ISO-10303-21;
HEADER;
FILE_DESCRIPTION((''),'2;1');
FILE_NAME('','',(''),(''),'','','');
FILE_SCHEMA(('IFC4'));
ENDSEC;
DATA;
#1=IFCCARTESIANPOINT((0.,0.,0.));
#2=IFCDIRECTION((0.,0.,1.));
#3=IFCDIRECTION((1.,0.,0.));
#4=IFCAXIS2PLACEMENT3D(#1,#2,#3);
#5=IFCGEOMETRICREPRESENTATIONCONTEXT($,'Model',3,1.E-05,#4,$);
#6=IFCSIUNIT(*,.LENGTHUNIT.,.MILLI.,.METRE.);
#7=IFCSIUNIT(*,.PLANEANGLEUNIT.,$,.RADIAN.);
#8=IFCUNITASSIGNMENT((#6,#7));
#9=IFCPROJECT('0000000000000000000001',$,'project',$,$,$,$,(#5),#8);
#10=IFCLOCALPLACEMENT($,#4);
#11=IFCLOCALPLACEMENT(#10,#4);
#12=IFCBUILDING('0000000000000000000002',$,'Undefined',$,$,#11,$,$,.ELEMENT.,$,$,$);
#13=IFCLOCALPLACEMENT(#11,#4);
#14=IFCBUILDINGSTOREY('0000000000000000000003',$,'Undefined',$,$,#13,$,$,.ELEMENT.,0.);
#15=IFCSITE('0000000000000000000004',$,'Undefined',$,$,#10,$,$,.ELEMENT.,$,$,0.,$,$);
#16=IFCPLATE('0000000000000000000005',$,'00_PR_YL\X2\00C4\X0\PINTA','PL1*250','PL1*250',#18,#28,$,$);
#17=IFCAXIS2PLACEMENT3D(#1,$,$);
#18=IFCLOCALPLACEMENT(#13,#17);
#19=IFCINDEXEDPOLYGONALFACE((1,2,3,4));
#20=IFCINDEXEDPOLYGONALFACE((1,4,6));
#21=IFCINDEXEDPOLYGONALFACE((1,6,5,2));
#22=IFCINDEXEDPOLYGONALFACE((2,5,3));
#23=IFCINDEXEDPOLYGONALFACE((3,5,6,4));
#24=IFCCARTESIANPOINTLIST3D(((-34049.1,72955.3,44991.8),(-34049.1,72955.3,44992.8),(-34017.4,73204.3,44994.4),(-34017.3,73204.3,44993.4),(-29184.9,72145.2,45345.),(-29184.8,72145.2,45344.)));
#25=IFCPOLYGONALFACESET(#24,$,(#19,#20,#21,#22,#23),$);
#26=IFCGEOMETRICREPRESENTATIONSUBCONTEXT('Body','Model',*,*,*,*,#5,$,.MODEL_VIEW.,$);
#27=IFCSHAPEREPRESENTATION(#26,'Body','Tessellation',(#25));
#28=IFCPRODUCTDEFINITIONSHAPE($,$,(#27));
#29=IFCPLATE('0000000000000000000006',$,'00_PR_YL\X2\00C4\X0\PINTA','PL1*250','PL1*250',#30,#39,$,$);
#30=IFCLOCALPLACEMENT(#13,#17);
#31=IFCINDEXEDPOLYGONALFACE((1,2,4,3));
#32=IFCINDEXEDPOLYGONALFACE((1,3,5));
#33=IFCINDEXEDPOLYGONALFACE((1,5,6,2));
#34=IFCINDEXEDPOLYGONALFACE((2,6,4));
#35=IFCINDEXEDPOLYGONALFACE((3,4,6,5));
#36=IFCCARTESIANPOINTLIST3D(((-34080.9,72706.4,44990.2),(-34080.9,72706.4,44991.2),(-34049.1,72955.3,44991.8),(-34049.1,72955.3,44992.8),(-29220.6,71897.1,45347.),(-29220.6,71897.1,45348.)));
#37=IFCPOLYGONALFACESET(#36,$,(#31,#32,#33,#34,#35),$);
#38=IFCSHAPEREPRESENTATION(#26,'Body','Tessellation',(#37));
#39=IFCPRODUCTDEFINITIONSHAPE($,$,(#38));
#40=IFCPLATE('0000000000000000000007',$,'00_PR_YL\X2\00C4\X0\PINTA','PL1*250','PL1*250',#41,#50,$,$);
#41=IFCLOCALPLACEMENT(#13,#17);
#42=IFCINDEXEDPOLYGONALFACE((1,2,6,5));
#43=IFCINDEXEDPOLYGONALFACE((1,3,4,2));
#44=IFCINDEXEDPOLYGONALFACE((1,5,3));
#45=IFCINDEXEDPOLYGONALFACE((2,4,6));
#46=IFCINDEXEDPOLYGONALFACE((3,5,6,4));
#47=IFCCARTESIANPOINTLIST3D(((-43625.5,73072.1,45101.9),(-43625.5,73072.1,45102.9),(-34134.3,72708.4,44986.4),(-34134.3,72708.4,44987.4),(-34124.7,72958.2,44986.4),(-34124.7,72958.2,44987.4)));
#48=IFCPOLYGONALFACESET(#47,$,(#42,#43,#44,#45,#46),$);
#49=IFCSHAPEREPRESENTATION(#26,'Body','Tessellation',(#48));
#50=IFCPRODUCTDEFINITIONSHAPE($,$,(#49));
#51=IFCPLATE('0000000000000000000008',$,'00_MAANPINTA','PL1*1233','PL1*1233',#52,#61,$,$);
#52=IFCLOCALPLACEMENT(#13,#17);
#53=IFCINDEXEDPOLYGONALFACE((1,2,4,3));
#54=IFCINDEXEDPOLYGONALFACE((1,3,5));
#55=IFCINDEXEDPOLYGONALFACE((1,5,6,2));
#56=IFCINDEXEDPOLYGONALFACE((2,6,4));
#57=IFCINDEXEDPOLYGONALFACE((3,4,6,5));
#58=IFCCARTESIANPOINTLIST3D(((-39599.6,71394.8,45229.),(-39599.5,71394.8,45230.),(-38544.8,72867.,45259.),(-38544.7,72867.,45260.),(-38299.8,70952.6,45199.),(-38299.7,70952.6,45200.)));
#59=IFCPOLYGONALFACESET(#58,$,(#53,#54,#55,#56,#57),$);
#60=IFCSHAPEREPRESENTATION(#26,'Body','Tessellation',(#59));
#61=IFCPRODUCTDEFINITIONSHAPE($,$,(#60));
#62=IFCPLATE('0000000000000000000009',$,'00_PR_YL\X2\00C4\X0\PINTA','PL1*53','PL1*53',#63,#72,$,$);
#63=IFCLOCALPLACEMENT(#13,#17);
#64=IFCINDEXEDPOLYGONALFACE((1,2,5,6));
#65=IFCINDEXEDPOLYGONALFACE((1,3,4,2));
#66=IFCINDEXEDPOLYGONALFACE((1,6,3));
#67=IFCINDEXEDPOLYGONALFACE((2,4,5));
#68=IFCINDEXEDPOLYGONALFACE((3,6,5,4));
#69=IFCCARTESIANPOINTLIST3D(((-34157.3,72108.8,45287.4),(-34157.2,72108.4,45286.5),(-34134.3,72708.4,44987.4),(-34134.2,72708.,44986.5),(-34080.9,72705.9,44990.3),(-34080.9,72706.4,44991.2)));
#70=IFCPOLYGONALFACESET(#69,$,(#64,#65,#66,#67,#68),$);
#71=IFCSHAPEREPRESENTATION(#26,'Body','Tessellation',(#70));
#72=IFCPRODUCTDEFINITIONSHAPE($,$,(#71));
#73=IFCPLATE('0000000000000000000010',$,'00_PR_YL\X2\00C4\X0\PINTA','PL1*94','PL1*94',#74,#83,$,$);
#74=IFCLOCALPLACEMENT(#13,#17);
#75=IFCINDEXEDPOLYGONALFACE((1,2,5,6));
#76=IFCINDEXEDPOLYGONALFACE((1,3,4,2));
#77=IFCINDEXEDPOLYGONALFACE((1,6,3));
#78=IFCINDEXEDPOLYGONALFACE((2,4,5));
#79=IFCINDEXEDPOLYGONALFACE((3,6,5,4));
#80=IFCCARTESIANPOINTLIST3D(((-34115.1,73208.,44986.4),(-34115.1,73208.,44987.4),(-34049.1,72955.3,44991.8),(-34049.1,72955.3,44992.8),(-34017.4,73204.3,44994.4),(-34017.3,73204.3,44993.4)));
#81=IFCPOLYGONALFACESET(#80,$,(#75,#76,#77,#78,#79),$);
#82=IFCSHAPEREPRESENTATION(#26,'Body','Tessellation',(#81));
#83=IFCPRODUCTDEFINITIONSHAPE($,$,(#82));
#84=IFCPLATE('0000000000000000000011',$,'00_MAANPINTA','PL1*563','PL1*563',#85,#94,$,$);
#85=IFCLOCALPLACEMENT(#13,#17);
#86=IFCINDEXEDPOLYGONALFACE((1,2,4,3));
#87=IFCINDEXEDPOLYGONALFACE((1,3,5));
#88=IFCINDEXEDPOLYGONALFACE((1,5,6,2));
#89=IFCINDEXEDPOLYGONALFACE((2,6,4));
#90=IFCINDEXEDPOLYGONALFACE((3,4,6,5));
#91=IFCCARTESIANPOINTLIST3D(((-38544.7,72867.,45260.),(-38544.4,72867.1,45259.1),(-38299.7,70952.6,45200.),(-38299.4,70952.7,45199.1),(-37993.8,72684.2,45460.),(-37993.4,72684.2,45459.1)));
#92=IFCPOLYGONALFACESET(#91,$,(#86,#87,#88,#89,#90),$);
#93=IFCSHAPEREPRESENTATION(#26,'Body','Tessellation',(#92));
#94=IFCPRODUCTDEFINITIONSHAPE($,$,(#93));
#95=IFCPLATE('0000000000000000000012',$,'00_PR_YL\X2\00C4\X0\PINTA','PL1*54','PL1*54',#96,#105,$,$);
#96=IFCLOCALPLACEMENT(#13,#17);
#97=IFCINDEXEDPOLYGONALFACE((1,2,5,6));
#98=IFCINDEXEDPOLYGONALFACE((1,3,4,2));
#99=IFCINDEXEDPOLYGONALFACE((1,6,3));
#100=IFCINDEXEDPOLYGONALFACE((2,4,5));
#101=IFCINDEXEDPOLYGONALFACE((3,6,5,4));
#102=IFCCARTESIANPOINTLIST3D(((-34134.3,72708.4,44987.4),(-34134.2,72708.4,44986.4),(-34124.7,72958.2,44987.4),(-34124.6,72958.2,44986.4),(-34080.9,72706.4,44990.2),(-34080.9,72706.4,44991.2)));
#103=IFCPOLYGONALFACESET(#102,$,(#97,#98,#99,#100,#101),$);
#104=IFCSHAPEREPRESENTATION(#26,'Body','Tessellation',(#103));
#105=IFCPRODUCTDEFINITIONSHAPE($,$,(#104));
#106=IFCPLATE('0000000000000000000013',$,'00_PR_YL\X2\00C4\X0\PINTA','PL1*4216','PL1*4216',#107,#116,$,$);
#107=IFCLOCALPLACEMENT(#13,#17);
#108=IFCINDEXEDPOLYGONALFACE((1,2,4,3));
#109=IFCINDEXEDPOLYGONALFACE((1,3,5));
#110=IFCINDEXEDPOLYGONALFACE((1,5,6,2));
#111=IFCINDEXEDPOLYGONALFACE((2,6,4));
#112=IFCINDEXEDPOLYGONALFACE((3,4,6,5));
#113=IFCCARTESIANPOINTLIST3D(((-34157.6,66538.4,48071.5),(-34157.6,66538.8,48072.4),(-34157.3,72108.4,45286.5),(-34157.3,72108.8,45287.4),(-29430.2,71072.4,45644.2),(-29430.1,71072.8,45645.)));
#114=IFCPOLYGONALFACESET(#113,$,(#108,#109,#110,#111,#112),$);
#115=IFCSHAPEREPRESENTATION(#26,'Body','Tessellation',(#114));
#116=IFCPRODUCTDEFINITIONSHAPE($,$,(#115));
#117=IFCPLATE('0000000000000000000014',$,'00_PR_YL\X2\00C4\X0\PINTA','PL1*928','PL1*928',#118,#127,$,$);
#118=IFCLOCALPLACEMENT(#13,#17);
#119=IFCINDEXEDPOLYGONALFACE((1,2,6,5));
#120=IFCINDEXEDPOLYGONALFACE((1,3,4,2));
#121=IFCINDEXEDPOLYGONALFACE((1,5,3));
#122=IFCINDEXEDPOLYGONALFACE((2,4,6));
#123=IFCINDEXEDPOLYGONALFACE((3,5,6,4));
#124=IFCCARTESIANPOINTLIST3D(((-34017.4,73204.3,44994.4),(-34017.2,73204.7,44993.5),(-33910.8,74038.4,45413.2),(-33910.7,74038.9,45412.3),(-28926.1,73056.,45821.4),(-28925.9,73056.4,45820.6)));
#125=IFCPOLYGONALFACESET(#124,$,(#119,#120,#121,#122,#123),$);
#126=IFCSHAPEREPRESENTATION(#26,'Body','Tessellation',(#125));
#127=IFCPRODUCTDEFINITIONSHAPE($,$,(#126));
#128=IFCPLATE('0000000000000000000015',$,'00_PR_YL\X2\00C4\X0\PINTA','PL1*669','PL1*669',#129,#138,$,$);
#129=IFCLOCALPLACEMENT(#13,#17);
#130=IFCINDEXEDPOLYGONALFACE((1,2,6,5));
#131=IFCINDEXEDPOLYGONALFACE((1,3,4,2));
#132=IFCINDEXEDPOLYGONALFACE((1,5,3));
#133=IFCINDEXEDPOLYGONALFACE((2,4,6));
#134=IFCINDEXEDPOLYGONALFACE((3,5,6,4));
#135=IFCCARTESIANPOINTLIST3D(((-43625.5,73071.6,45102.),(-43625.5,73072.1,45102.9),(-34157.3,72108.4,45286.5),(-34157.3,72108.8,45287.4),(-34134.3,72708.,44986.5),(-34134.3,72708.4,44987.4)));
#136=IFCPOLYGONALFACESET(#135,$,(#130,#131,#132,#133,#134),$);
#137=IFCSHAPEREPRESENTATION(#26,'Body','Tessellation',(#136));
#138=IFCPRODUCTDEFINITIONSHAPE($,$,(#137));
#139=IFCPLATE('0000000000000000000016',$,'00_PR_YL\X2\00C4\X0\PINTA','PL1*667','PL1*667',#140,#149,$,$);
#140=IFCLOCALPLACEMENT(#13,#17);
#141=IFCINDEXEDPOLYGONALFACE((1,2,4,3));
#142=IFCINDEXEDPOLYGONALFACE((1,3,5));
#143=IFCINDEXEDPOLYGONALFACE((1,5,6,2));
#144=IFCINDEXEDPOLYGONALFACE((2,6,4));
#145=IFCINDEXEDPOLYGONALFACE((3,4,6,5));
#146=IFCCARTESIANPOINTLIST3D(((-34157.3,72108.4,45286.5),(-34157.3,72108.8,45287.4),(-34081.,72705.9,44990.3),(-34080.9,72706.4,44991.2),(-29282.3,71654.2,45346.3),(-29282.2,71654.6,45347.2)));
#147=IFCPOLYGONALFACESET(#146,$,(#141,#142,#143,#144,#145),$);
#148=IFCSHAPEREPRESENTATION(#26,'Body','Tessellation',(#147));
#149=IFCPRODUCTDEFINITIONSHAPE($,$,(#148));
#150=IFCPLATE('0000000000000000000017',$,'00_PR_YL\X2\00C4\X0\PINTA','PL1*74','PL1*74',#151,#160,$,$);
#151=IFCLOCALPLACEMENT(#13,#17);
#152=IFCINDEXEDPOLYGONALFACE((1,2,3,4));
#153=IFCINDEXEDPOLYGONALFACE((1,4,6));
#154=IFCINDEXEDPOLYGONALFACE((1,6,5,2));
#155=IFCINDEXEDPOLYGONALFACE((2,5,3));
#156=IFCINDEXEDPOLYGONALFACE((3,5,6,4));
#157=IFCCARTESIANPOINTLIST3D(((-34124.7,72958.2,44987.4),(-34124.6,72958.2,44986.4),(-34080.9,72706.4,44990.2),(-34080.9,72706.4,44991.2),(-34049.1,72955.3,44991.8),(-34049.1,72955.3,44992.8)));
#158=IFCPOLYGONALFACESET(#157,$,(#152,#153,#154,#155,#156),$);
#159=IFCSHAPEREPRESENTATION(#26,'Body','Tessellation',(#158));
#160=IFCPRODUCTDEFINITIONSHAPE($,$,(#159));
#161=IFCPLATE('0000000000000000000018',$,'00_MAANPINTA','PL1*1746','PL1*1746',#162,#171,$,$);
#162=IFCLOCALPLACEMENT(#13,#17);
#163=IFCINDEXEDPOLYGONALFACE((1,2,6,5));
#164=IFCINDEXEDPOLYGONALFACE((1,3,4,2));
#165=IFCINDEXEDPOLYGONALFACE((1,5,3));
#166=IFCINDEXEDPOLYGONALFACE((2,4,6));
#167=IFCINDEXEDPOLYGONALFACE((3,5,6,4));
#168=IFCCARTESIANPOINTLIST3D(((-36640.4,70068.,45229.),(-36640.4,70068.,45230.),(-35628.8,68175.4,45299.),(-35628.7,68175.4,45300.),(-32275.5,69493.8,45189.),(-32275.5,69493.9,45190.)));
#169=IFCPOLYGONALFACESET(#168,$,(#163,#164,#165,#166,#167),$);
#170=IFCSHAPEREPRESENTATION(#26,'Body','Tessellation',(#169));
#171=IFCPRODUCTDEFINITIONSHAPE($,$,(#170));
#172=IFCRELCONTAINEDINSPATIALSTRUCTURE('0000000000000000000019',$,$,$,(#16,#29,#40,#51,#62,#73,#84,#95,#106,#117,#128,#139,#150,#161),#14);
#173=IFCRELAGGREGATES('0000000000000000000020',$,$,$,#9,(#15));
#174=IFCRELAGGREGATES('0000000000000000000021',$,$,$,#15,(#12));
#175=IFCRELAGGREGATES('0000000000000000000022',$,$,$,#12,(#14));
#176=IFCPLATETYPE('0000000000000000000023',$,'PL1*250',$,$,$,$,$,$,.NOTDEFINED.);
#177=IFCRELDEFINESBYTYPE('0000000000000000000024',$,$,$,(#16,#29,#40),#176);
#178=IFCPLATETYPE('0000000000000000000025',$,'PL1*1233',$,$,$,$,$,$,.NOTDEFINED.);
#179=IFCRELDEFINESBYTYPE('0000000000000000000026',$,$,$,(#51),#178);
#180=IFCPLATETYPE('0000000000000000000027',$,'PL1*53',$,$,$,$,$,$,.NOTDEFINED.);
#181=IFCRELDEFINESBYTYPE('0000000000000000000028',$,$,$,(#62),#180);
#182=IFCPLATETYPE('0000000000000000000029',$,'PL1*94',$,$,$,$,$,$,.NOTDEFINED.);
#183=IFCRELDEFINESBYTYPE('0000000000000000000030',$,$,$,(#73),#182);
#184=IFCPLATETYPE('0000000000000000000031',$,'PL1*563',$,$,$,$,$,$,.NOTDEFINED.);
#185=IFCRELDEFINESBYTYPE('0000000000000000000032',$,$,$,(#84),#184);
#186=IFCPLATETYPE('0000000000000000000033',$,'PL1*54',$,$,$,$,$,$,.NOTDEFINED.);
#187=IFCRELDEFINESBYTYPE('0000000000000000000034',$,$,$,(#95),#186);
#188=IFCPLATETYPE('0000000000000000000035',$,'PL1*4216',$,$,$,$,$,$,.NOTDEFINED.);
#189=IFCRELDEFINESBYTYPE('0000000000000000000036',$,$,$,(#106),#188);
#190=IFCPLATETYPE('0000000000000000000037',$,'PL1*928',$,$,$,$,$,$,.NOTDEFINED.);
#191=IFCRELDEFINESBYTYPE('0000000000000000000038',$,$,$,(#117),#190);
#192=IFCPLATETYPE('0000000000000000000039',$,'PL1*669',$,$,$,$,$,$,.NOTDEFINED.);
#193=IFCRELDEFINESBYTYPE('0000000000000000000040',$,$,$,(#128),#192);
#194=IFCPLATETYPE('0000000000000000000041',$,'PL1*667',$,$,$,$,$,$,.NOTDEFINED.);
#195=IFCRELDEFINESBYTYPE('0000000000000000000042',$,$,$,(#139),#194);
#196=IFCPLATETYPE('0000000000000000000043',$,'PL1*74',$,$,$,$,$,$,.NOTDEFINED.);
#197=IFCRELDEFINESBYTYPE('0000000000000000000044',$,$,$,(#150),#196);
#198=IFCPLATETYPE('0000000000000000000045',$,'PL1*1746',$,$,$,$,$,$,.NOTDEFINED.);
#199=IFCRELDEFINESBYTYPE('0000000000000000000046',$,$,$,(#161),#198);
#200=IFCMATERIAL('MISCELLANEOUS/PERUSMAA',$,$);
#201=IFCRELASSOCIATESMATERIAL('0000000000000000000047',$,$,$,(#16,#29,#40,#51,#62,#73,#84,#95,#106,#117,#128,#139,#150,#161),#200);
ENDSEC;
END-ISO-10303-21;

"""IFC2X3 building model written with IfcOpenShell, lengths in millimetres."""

from ifc_helpers import new_model, si_unit, frame, origin_with_axes, place, context, subcontext, project, spatial, polyline, outline, extrude, material, type_object, element, save


model = new_model("IFC2X3")

# Units and contexts
model_context = context("Model", 3, precision=1e-05, world=origin_with_axes())
body_context = subcontext(model_context, "Body", "Model", "MODEL_VIEW")
ifc_project = project(units=[si_unit("LENGTHUNIT", "METRE", prefix="MILLI"), si_unit("PLANEANGLEUNIT", "RADIAN")], contexts=[model_context])

# Site, building, storey
site_placement = place(None, origin_with_axes())
site = spatial("IfcSite", under=ifc_project, at=site_placement, Name="Undefined", CompositionType="ELEMENT", RefElevation=0.0)
building_placement = place(site_placement, origin_with_axes())
building = spatial("IfcBuilding", under=site, at=building_placement, Name="Undefined", CompositionType="ELEMENT")
storey_placement = place(building_placement, origin_with_axes())
storey = spatial("IfcBuildingStorey", under=building, at=storey_placement, Name="Undefined", CompositionType="ELEMENT", Elevation=0.0)

# Plates
ifc_material = material(Name="MISCELLANEOUS/PERUSMAA")
plate_type_1 = type_object("IfcPlateType", Name="PL1*250", PredefinedType="NOTDEFINED")
plate_1_placement = place(storey_placement, frame((-34049.1, 72955.3, 44992.3), z_axis=(0.071752, -0.00285, -0.997418), x_axis=(0.12668, 0.991924, 0.006279)))
element("IfcPlate", 1, at=plate_1_placement, inside=storey, type_object=plate_type_1, material=ifc_material, Name="00_PR_YLÄPINTA", Description="PL1*250", ObjectType="PL1*250", context=body_context, shape_type="SweptSolid", body=[
    extrude(outline(polyline([(0.0, 0.0), (251.0, 0.0), (-185.2, 4940.3), (0.0, 0.0)])), frame((0.0, 0.0, -0.5), z_axis=(0.0, 0.0, 1.0), x_axis=(1.0, 0.0, 0.0)), (0.0, 0.0, 1.0), 1.0),
])
plate_2_placement = place(storey_placement, frame((-34080.9, 72706.4, 44990.7), z_axis=(0.072733, -0.002904, -0.997347), x_axis=(0.126685, 0.991923, 0.006351)))
element("IfcPlate", 2, at=plate_2_placement, inside=storey, type_object=plate_type_1, material=ifc_material, Name="00_PR_YLÄPINTA", Description="PL1*250", ObjectType="PL1*250", context=body_context, shape_type="SweptSolid", body=[
    extrude(outline(polyline([(0.0, 0.0), (251.0, 0.0), (-184.8, 4936.7), (0.0, 0.0)])), frame((0.0, 0.0, -0.5), z_axis=(0.0, 0.0, 1.0), x_axis=(1.0, 0.0, 0.0)), (0.0, 0.0, 1.0), 1.0),
])
plate_3_placement = place(storey_placement, frame((-34124.7, 72958.2, 44986.9), z_axis=(-0.012153, 0.000466, -0.999926), x_axis=(-0.038286, -0.999267, 0.0)))
element("IfcPlate", 3, at=plate_3_placement, inside=storey, type_object=plate_type_1, material=ifc_material, Name="00_PR_YLÄPINTA", Description="PL1*250", ObjectType="PL1*250", context=body_context, shape_type="SweptSolid", body=[
    extrude(outline(polyline([(0.0, 0.0), (250.0, 0.0), (250.0, 9498.9), (0.0, 0.0)])), frame((0.0, 0.0, -0.5), z_axis=(0.0, 0.0, 1.0), x_axis=(1.0, 0.0, 0.0)), (0.0, 0.0, 1.0), 1.0),
])
plate_type_2 = type_object("IfcPlateType", Name="PL1*1233", PredefinedType="NOTDEFINED")
plate_4_placement = place(storey_placement, frame((-38299.8, 70952.6, 45199.5), z_axis=(-0.012977, 0.029664, -0.999476), x_axis=(-0.946487, 0.322001, 0.021845)))
element("IfcPlate", 4, at=plate_4_placement, inside=storey, type_object=plate_type_2, material=ifc_material, Name="00_MAANPINTA", Description="PL1*1233", ObjectType="PL1*1233", context=body_context, shape_type="SweptSolid", body=[
    extrude(outline(polyline([(0.0, 0.0), (1373.3, 0.0), (849.6, 1734.0), (0.0, 0.0)])), frame((0.0, 0.0, -0.5), z_axis=(0.0, 0.0, 1.0), x_axis=(1.0, 0.0, 0.0)), (0.0, 0.0, 1.0), 1.0),
])
plate_type_3 = type_object("IfcPlateType", Name="PL1*53", PredefinedType="NOTDEFINED")
plate_5_placement = place(storey_placement, frame((-34157.2, 72108.6, 45286.9), z_axis=(0.047415, -0.448425, -0.892562), x_axis=(0.034247, 0.893771, -0.447213)))
element("IfcPlate", 5, at=plate_5_placement, inside=storey, type_object=plate_type_3, material=ifc_material, Name="00_PR_YLÄPINTA", Description="PL1*53", ObjectType="PL1*53", context=body_context, shape_type="SweptSolid", body=[
    extrude(outline(polyline([(0.0, 0.0), (670.8, 0.0), (669.1, 53.5), (0.0, 0.0)])), frame((0.0, 0.0, -0.5), z_axis=(0.0, 0.0, 1.0), x_axis=(1.0, 0.0, 0.0)), (0.0, 0.0, 1.0), 1.0),
])
plate_type_4 = type_object("IfcPlateType", Name="PL1*94", PredefinedType="NOTDEFINED")
plate_6_placement = place(storey_placement, frame((-34049.1, 72955.3, 44992.3), z_axis=(0.071597, -0.00283, -0.99743), x_axis=(-0.25261, 0.967343, -0.020877)))
element("IfcPlate", 6, at=plate_6_placement, inside=storey, type_object=plate_type_4, material=ifc_material, Name="00_PR_YLÄPINTA", Description="PL1*94", ObjectType="PL1*94", context=body_context, shape_type="SweptSolid", body=[
    extrude(outline(polyline([(0.0, 0.0), (261.2, 0.0), (232.8, 93.9), (0.0, 0.0)])), frame((0.0, 0.0, -0.5), z_axis=(0.0, 0.0, 1.0), x_axis=(1.0, 0.0, 0.0)), (0.0, 0.0, 1.0), 1.0),
])
plate_type_5 = type_object("IfcPlateType", Name="PL1*563", PredefinedType="NOTDEFINED")
plate_7_placement = place(storey_placement, frame((-38544.6, 72867.0, 45259.5), z_axis=(0.362271, 0.075479, -0.929012), x_axis=(0.897349, -0.297766, 0.325731)))
element("IfcPlate", 7, at=plate_7_placement, inside=storey, type_object=plate_type_5, material=ifc_material, Name="00_MAANPINTA", Description="PL1*563", ObjectType="PL1*563", context=body_context, shape_type="SweptSolid", body=[
    extrude(outline(polyline([(0.0, 0.0), (614.0, 0.0), (770.4, 1770.6), (0.0, 0.0)])), frame((0.0, 0.0, -0.5), z_axis=(0.0, 0.0, 1.0), x_axis=(1.0, 0.0, 0.0)), (0.0, 0.0, 1.0), 1.0),
])
plate_type_6 = type_object("IfcPlateType", Name="PL1*54", PredefinedType="NOTDEFINED")
plate_8_placement = place(storey_placement, frame((-34124.7, 72958.2, 44986.9), z_axis=(0.072073, -0.002761, -0.997396), x_axis=(0.171191, -0.985122, 0.015098)))
element("IfcPlate", 8, at=plate_8_placement, inside=storey, type_object=plate_type_6, material=ifc_material, Name="00_PR_YLÄPINTA", Description="PL1*54", ObjectType="PL1*54", context=body_context, shape_type="SweptSolid", body=[
    extrude(outline(polyline([(0.0, 0.0), (255.7, 0.0), (244.5, 52.3), (0.0, 0.0)])), frame((0.0, 0.0, -0.5), z_axis=(0.0, 0.0, 1.0), x_axis=(1.0, 0.0, 0.0)), (0.0, 0.0, 1.0), 1.0),
])
plate_type_7 = type_object("IfcPlateType", Name="PL1*4216", PredefinedType="NOTDEFINED")
plate_9_placement = place(storey_placement, frame((-34157.3, 72108.6, 45286.9), z_axis=(-0.030323, -0.447006, -0.894017), x_axis=(0.974157, -0.213505, 0.073712)))
element("IfcPlate", 9, at=plate_9_placement, inside=storey, type_object=plate_type_7, material=ifc_material, Name="00_PR_YLÄPINTA", Description="PL1*4216", ObjectType="PL1*4216", context=body_context, shape_type="SweptSolid", body=[
    extrude(outline(polyline([(0.0, 0.0), (4852.5, 0.0), (1394.2, 6069.4), (0.0, 0.0)])), frame((0.0, 0.0, -0.5), z_axis=(0.0, 0.0, 1.0), x_axis=(1.0, 0.0, 0.0)), (0.0, 0.0, 1.0), 1.0),
])
plate_type_8 = type_object("IfcPlateType", Name="PL1*928", PredefinedType="NOTDEFINED")
plate_10_placement = place(storey_placement, frame((-34017.3, 73204.5, 44993.9), z_axis=(0.157096, 0.42703, -0.890486), x_axis=(0.113402, 0.887918, 0.445804)))
element("IfcPlate", 10, at=plate_10_placement, inside=storey, type_object=plate_type_8, material=ifc_material, Name="00_PR_YLÄPINTA", Description="PL1*928", ObjectType="PL1*928", context=body_context, shape_type="SweptSolid", body=[
    extrude(outline(polyline([(0.0, 0.0), (939.4, 0.0), (814.4, 5095.5), (0.0, 0.0)])), frame((0.0, 0.0, -0.5), z_axis=(0.0, 0.0, 1.0), x_axis=(1.0, 0.0, 0.0)), (0.0, 0.0, 1.0), 1.0),
])
plate_type_9 = type_object("IfcPlateType", Name="PL1*669", PredefinedType="NOTDEFINED")
plate_11_placement = place(storey_placement, frame((-34134.3, 72708.2, 44986.9), z_axis=(-0.027992, -0.446443, -0.894374), x_axis=(-0.034247, -0.893771, 0.447213)))
element("IfcPlate", 11, at=plate_11_placement, inside=storey, type_object=plate_type_9, material=ifc_material, Name="00_PR_YLÄPINTA", Description="PL1*669", ObjectType="PL1*669", context=body_context, shape_type="SweptSolid", body=[
    extrude(outline(polyline([(0.0, 0.0), (670.8, 0.0), (51.7, 9498.7), (0.0, 0.0)])), frame((0.0, 0.0, -0.5), z_axis=(0.0, 0.0, 1.0), x_axis=(1.0, 0.0, 0.0)), (0.0, 0.0, 1.0), 1.0),
])
plate_type_10 = type_object("IfcPlateType", Name="PL1*667", PredefinedType="NOTDEFINED")
plate_12_placement = place(storey_placement, frame((-34157.3, 72108.6, 45286.9), z_axis=(-0.030066, -0.440784, -0.89711), x_axis=(0.11369, 0.890183, -0.44119)))
element("IfcPlate", 12, at=plate_12_placement, inside=storey, type_object=plate_type_10, material=ifc_material, Name="00_PR_YLÄPINTA", Description="PL1*667", ObjectType="PL1*667", context=body_context, shape_type="SweptSolid", body=[
    extrude(outline(polyline([(0.0, 0.0), (671.2, 0.0), (123.5, 4894.9), (0.0, 0.0)])), frame((0.0, 0.0, -0.5), z_axis=(0.0, 0.0, 1.0), x_axis=(1.0, 0.0, 0.0)), (0.0, 0.0, 1.0), 1.0),
])
plate_type_11 = type_object("IfcPlateType", Name="PL1*74", PredefinedType="NOTDEFINED")
plate_13_placement = place(storey_placement, frame((-34080.9, 72706.4, 44990.7), z_axis=(0.071883, -0.002795, -0.997409), x_axis=(-0.171191, 0.985122, -0.015098)))
element("IfcPlate", 13, at=plate_13_placement, inside=storey, type_object=plate_type_11, material=ifc_material, Name="00_PR_YLÄPINTA", Description="PL1*74", ObjectType="PL1*74", context=body_context, shape_type="SweptSolid", body=[
    extrude(outline(polyline([(0.0, 0.0), (255.7, 0.0), (239.8, 74.1), (0.0, 0.0)])), frame((0.0, 0.0, -0.5), z_axis=(0.0, 0.0, 1.0), x_axis=(1.0, 0.0, 0.0)), (0.0, 0.0, 1.0), 1.0),
])
plate_type_12 = type_object("IfcPlateType", Name="PL1*1746", PredefinedType="NOTDEFINED")
plate_14_placement = place(storey_placement, frame((-35628.7, 68175.4, 45299.5), z_axis=(-0.015073, -0.045002, -0.998873), x_axis=(-0.471159, 0.881446, -0.032602)))
element("IfcPlate", 14, at=plate_14_placement, inside=storey, type_object=plate_type_12, material=ifc_material, Name="00_MAANPINTA", Description="PL1*1746", ObjectType="PL1*1746", context=body_context, shape_type="SweptSolid", body=[
    extrude(outline(polyline([(0.0, 0.0), (2147.1, 0.0), (-414.2, 3580.9), (0.0, 0.0)])), frame((0.0, 0.0, -0.5), z_axis=(0.0, 0.0, 1.0), x_axis=(1.0, 0.0, 0.0)), (0.0, 0.0, 1.0), 1.0),
])

save(model, "model.ifc")
